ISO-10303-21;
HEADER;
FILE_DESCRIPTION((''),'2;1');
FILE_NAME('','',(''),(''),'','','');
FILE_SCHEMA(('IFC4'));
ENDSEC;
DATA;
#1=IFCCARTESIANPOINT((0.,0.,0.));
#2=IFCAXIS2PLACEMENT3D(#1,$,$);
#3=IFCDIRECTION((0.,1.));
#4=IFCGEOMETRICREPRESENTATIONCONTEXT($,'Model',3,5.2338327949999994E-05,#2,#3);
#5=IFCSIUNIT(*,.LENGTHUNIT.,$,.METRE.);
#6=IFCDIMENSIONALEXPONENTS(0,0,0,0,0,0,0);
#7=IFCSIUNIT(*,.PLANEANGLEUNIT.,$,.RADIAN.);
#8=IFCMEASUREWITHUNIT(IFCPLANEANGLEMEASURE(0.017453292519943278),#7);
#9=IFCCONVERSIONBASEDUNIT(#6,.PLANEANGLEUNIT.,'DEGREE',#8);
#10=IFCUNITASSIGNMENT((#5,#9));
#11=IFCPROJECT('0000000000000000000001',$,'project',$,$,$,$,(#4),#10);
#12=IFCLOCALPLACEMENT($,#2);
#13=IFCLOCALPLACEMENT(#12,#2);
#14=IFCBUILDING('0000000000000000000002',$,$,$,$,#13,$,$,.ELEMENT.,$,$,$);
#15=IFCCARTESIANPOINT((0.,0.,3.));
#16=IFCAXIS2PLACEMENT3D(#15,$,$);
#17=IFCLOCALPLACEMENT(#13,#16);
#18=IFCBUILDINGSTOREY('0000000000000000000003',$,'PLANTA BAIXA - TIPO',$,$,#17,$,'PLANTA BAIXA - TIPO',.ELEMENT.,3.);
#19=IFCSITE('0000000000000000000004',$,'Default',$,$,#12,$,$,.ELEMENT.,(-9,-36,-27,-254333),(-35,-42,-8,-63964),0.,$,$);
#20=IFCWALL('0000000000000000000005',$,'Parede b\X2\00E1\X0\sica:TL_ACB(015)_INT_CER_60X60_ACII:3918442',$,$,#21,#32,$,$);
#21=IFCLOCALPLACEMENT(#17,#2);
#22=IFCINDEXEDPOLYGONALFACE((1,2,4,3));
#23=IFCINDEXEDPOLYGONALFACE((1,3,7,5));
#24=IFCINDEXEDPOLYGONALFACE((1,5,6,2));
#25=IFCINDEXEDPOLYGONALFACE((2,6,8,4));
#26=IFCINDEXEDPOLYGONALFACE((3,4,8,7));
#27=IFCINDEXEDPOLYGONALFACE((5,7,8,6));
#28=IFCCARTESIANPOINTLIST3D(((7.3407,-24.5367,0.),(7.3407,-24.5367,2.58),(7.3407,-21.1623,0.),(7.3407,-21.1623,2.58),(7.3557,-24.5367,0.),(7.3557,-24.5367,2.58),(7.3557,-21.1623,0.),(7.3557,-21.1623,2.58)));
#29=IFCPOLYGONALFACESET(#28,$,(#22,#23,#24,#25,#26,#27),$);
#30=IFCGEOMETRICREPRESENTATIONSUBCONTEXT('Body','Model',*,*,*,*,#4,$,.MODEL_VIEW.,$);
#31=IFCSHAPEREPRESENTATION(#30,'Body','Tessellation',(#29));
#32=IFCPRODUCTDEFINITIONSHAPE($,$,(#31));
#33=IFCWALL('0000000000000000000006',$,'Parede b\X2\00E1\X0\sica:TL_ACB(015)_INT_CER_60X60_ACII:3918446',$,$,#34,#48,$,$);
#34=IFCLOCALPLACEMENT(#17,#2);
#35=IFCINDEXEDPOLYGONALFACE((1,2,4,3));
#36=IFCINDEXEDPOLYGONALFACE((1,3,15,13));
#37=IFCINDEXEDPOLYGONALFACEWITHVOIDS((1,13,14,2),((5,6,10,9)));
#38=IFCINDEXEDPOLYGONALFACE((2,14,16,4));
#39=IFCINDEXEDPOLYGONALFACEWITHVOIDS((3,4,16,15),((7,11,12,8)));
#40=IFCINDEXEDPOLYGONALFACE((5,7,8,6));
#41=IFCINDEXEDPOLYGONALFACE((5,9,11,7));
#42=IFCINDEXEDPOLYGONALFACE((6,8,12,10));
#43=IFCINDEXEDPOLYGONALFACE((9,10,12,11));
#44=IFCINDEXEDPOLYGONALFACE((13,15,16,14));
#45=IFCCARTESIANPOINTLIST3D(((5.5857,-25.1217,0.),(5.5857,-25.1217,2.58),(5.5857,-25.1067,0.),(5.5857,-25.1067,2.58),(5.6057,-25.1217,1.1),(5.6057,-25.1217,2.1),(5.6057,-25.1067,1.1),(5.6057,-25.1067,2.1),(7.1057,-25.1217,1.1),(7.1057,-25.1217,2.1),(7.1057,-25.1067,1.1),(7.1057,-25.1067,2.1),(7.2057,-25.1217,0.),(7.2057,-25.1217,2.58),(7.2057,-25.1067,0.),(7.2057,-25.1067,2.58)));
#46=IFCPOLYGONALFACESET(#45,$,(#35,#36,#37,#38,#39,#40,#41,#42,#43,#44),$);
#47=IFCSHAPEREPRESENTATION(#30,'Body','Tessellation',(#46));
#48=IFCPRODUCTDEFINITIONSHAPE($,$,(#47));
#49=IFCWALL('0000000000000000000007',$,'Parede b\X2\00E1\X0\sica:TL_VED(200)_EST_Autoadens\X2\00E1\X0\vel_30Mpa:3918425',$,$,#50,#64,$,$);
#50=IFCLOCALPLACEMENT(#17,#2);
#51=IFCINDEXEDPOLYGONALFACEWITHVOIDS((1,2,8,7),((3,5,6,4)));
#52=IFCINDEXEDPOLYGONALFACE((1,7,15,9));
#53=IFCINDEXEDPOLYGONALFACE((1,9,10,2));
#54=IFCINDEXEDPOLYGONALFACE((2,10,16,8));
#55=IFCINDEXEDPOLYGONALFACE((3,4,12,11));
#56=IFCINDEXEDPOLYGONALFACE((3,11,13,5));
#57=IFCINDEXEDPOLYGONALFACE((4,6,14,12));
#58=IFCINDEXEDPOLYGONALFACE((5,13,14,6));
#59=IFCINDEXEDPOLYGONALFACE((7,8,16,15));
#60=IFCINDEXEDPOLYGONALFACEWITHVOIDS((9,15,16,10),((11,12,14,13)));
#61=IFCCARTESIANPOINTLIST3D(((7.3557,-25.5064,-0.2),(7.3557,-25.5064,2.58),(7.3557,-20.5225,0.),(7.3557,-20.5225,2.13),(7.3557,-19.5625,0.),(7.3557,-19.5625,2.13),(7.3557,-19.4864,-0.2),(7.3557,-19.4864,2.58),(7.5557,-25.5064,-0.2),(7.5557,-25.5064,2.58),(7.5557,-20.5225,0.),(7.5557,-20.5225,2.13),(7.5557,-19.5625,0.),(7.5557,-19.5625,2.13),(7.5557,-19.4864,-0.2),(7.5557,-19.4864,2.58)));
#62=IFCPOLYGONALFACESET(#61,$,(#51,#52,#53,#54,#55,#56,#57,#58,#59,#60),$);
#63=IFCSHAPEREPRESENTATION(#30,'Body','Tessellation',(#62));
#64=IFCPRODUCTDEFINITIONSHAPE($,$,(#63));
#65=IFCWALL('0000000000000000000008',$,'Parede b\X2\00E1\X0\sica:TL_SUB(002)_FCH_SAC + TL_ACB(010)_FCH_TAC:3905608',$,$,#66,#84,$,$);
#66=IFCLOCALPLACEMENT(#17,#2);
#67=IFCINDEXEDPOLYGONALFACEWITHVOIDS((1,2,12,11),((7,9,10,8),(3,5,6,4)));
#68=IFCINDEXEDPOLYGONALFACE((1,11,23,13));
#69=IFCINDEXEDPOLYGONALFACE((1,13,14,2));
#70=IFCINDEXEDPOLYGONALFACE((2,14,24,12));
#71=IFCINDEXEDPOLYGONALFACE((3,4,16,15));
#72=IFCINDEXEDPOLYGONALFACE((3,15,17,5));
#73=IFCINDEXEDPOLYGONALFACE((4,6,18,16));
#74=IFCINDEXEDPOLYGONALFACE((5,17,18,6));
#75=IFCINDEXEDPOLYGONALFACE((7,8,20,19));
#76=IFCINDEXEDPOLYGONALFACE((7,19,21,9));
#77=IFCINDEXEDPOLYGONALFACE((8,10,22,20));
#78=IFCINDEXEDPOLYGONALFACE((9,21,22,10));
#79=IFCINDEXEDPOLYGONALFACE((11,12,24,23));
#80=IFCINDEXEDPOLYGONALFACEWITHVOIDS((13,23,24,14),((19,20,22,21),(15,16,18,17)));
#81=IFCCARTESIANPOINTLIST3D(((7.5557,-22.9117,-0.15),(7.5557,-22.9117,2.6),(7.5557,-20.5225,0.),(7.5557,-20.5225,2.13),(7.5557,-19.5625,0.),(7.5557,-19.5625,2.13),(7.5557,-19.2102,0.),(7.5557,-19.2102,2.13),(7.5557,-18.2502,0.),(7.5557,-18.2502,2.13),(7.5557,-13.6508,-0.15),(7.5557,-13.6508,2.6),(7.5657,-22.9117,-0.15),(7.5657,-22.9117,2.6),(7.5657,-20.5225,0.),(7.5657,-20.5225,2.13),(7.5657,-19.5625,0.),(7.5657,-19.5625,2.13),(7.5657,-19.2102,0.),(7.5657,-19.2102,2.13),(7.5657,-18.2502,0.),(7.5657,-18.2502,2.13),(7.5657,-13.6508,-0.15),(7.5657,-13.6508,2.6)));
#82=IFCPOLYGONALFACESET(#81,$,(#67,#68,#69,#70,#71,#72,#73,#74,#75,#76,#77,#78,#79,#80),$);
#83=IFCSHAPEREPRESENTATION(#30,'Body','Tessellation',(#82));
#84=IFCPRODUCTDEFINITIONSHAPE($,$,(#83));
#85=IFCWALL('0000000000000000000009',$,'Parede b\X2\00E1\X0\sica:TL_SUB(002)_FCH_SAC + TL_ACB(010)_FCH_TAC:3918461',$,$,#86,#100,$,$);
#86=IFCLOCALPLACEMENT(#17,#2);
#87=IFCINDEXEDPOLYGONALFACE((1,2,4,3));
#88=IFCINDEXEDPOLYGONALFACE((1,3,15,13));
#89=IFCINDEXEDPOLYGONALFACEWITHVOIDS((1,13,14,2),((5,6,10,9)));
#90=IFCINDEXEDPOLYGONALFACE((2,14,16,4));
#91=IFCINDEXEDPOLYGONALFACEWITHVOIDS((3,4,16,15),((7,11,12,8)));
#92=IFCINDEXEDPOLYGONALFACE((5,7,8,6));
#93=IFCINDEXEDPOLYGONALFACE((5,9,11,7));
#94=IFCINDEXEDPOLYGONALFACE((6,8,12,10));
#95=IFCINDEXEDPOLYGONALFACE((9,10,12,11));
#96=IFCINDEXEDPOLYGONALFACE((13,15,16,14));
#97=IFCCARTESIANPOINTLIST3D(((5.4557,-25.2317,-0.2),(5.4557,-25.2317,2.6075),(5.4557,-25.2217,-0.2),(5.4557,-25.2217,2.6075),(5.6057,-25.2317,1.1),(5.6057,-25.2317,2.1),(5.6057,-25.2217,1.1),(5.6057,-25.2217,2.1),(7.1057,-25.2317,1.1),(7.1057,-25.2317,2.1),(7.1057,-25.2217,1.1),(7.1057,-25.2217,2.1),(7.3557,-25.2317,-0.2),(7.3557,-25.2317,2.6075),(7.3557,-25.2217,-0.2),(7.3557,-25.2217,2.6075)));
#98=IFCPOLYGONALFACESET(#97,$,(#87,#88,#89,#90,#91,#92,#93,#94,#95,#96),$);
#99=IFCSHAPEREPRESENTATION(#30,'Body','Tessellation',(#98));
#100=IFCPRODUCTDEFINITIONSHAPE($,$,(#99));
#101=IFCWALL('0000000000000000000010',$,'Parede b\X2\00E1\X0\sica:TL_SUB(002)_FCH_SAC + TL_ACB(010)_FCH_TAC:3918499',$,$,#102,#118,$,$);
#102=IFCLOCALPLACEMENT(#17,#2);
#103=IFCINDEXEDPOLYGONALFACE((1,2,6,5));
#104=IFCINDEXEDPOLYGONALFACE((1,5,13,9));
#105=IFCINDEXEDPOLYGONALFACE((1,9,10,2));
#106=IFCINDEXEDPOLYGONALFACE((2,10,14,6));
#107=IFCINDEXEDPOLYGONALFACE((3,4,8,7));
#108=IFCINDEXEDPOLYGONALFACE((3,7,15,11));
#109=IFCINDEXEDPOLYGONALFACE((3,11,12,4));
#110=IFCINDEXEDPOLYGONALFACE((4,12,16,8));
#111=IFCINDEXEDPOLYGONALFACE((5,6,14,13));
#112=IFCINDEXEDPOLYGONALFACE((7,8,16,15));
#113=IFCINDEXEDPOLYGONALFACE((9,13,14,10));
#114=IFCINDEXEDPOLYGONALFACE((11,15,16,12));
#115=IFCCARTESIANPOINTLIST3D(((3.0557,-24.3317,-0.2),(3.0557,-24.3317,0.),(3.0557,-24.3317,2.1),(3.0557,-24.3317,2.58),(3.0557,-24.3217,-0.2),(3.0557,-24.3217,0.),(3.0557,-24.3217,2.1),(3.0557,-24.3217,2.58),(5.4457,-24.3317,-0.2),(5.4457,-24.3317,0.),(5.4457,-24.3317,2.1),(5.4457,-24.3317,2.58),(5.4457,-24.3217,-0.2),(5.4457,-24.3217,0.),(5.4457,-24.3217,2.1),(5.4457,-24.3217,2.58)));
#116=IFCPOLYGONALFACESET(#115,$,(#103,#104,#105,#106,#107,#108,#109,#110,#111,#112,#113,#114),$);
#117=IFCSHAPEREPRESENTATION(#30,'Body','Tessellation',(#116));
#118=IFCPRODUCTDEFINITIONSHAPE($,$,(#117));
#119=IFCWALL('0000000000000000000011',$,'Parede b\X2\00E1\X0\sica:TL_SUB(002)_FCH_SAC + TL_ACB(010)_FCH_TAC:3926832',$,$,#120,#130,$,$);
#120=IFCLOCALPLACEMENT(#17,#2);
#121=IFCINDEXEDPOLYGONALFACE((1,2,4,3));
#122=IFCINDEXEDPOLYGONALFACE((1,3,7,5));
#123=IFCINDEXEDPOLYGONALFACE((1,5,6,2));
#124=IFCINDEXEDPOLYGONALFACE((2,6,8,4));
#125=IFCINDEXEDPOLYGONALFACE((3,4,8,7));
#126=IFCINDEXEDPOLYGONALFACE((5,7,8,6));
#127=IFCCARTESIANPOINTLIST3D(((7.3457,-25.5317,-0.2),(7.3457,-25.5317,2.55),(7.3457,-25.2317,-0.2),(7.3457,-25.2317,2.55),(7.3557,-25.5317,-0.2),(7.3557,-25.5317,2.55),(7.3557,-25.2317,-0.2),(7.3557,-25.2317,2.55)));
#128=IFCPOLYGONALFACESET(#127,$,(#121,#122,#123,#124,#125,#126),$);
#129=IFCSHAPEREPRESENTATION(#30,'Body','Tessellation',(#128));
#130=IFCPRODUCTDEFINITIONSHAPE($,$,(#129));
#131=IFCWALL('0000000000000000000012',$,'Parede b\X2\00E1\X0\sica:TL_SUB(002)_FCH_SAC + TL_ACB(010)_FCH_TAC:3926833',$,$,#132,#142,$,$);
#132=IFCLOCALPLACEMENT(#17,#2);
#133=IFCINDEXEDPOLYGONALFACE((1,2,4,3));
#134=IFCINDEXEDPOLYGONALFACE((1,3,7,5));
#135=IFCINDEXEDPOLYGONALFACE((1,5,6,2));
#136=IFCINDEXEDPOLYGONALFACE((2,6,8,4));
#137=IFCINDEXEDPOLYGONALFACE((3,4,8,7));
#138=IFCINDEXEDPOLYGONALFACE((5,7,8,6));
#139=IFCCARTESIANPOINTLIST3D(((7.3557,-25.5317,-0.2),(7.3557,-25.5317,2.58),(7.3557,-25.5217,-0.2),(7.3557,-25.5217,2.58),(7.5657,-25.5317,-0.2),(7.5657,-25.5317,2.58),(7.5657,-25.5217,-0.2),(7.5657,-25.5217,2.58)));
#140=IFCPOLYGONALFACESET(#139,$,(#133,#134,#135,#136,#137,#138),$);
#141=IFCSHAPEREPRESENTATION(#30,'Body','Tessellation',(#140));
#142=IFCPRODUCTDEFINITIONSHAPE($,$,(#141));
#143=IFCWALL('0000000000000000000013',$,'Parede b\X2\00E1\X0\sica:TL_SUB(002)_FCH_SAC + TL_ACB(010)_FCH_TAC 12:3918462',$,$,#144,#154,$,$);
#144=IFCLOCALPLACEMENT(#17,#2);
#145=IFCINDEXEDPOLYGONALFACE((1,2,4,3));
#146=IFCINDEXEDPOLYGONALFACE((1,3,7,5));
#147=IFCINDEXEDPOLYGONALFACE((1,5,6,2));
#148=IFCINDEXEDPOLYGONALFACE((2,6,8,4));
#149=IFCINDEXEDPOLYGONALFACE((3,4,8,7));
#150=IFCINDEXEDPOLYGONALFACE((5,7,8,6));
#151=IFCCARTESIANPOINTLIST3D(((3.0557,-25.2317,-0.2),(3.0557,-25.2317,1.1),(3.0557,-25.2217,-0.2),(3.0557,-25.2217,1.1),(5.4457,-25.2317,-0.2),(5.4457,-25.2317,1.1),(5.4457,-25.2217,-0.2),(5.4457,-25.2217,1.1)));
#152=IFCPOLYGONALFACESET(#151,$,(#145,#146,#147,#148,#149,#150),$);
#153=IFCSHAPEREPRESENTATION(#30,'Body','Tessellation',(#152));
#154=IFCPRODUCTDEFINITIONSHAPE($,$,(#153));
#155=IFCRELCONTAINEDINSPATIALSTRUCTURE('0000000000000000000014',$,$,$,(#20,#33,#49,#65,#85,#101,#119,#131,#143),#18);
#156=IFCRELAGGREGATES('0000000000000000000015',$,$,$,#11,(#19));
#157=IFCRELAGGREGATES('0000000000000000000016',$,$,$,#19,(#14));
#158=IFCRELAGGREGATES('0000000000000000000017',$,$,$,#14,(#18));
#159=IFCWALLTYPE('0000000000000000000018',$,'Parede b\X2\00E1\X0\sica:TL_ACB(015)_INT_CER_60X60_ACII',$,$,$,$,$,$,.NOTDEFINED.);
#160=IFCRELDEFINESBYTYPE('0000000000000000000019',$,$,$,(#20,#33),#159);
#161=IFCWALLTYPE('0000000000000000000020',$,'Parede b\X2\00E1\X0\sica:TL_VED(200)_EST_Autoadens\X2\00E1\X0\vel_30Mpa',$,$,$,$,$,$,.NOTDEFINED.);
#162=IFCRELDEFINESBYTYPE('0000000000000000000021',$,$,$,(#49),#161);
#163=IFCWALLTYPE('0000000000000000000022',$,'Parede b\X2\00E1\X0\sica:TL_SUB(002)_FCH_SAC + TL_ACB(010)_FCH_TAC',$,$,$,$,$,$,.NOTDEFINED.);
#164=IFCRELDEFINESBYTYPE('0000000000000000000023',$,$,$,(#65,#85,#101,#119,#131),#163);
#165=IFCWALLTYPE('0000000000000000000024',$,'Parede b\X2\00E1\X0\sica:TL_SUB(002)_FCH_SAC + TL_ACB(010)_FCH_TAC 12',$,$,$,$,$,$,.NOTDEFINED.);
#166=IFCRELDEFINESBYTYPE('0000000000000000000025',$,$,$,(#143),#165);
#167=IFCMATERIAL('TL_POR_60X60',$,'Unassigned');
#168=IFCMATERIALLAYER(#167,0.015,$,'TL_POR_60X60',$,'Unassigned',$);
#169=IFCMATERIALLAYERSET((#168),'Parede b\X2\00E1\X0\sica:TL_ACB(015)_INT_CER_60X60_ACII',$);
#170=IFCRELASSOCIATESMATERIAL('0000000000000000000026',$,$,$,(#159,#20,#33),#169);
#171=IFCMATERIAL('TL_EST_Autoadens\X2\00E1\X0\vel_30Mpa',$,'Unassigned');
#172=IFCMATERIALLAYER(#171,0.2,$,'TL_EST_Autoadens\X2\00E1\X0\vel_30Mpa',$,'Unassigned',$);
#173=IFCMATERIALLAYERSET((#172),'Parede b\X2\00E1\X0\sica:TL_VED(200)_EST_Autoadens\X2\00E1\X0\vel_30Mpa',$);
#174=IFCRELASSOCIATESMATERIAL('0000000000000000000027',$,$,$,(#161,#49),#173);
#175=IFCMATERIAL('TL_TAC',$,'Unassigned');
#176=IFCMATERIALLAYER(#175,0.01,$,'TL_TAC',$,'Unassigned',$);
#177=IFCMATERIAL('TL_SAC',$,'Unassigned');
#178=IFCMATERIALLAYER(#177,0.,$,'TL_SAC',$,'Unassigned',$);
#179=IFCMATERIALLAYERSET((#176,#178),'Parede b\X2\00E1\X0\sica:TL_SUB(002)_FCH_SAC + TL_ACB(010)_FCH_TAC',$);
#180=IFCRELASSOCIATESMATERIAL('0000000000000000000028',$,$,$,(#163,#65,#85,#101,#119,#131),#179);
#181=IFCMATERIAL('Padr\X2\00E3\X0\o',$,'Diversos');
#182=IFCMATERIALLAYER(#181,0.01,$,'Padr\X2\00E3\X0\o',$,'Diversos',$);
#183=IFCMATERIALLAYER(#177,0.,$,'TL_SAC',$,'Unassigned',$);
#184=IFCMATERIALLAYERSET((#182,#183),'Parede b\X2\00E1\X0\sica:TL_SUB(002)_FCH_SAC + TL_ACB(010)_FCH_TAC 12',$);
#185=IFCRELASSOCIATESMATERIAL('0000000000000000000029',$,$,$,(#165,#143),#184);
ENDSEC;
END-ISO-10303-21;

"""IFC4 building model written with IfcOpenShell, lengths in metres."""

from ifc_helpers import new_model, entity, si_unit, converted_unit, direction, frame, frame_2d, origin, place, context, subcontext, project, spatial, rectangle, extrude, material, layer, layer_set, layer_usage, type_object, element, save


model = new_model("IFC4")

# Units and contexts
model_context = context("Model", 3, precision=5.2338327949999994e-05, world=origin(), true_north=direction((0.0, 1.0)))
body_context = subcontext(model_context, "Body", "Model", "MODEL_VIEW")
ifc_project = project(units=[si_unit("LENGTHUNIT", "METRE"), converted_unit("PLANEANGLEUNIT", "DEGREE", entity("IfcPlaneAngleMeasure", 0.017453292519943278), si_unit("PLANEANGLEUNIT", "RADIAN"), dimensions=[0, 0, 0, 0, 0, 0, 0])], contexts=[model_context])

# Site, building, storey
site_placement = place(None, frame((0.0, 0.0, 0.0)))
site = spatial("IfcSite", under=ifc_project, at=site_placement, Name="Default", CompositionType="ELEMENT", RefLatitude=(-9, -36, -27, -254333), RefLongitude=(-35, -42, -8, -63964), RefElevation=0.0)
building_placement = place(site_placement, origin())
building = spatial("IfcBuilding", under=site, at=building_placement, CompositionType="ELEMENT")
storey_placement = place(building_placement, frame((0.0, 0.0, 3.0)))
storey = spatial("IfcBuildingStorey", under=building, at=storey_placement, Name="PLANTA BAIXA - TIPO", LongName="PLANTA BAIXA - TIPO", CompositionType="ELEMENT", Elevation=3.0)

# Shared definitions
ifc_material_1 = material(Name="TL_EST_Autoadensável_30Mpa", Category="Unassigned")

# Shared definitions
ifc_material_2 = material(Name="TL_SAC", Category="Unassigned")

# Wall
ifc_material_3 = material(Name="TL_POR_60X60", Category="Unassigned")
ifc_layer_1 = layer(ifc_material_3, 0.015, Name="TL_POR_60X60", Category="Unassigned")
ifc_layer_set_1 = layer_set([ifc_layer_1], Name="Parede básica:TL_ACB(015)_INT_CER_60X60_ACII")
ifc_layer_usage_1 = layer_usage(ifc_layer_set_1, "AXIS2", "POSITIVE", -0.0075)
wall_type_1 = type_object("IfcWallType", Name="Parede básica:TL_ACB(015)_INT_CER_60X60_ACII", PredefinedType="NOTDEFINED", material=ifc_layer_set_1)
wall_1_placement = place(storey_placement, frame((7.3482, -21.1623, 0.0), z_axis=(0.0, 0.0, 1.0), x_axis=(0.0, -1.0, 0.0)))
element("IfcWall", 1, at=wall_1_placement, inside=storey, type_object=wall_type_1, material=ifc_layer_usage_1, Name="Parede básica:TL_ACB(015)_INT_CER_60X60_ACII:3918442", context=body_context, shape_type="SweptSolid", body=[
    extrude(rectangle(XDim=3.3744, YDim=0.015, at=frame_2d((1.6872, 0.0), x_axis=(-1.0, 0.0))), origin(), (0.0, 0.0, 1.0), 2.58),
])

# Walls, openings
ifc_layer_usage_2 = layer_usage(ifc_layer_set_1, "AXIS2", "POSITIVE", -0.0075)
wall_2_placement = place(storey_placement, frame((7.2057, -25.1142, 0.0), z_axis=(0.0, 0.0, 1.0), x_axis=(-1.0, 0.0, 0.0)))
wall_2 = element("IfcWall", 2, at=wall_2_placement, inside=storey, type_object=wall_type_1, material=ifc_layer_usage_2, Name="Parede básica:TL_ACB(015)_INT_CER_60X60_ACII:3918446", context=body_context, shape_type="SweptSolid", body=[
    extrude(rectangle(XDim=1.62, YDim=0.015, at=frame_2d((0.81, 0.0), x_axis=(-1.0, 0.0))), origin(), (0.0, 0.0, 1.0), 2.58),
])
opening_1_placement = place(wall_2_placement, frame((7.2057, -25.1142, 1.1)))
element("IfcOpeningElement", 3, at=opening_1_placement, cuts=wall_2, PredefinedType="OPENING", context=body_context, shape_type="SweptSolid", body=[
    extrude(rectangle(XDim=1.0, YDim=1.5, at=frame_2d((0.0, 0.0), x_axis=(0.0, 1.0))), frame((-6.3557, 23.5977, 0.5), z_axis=(0.0, 1.0, 0.0), x_axis=(1.0, 0.0, 0.0)), (0.0, 0.0, 1.0), 3.048),
])
ifc_layer_2 = layer(ifc_material_1, 0.2, Name="TL_EST_Autoadensável_30Mpa", Category="Unassigned")
ifc_layer_set_2 = layer_set([ifc_layer_2], Name="Parede básica:TL_VED(200)_EST_Autoadensável_30Mpa")
ifc_layer_usage_3 = layer_usage(ifc_layer_set_2, "AXIS2", "POSITIVE", -0.1)
wall_type_2 = type_object("IfcWallType", Name="Parede básica:TL_VED(200)_EST_Autoadensável_30Mpa", PredefinedType="NOTDEFINED", material=ifc_layer_set_2)
wall_3_placement = place(storey_placement, frame((7.4557, -25.5064, -0.2), z_axis=(0.0, 0.0, 1.0), x_axis=(0.0, 1.0, 0.0)))
wall_3 = element("IfcWall", 4, at=wall_3_placement, inside=storey, type_object=wall_type_2, material=ifc_layer_usage_3, Name="Parede básica:TL_VED(200)_EST_Autoadensável_30Mpa:3918425", context=body_context, shape_type="SweptSolid", body=[
    extrude(rectangle(XDim=6.02, YDim=0.2, at=frame_2d((3.01, 0.0), x_axis=(-1.0, 0.0))), origin(), (0.0, 0.0, 1.0), 2.78),
])
opening_2_placement = place(wall_3_placement, frame((4.9838, -0.1, 0.2)))
element("IfcOpeningElement", 5, at=opening_2_placement, cuts=wall_3, PredefinedType="OPENING", context=body_context, shape_type="SweptSolid", body=[
    extrude(rectangle(XDim=2.13, YDim=0.96, at=frame_2d((1.065, 0.48), x_axis=(1.0, 0.0))), frame((0.0, 0.0, 0.0), z_axis=(0.0, 1.0, 0.0), x_axis=(0.0, 0.0, 1.0)), (0.0, 0.0, 1.0), 0.2),
])

# Wall, openings
ifc_material_4 = material(Name="TL_TAC", Category="Unassigned")
ifc_layer_3 = layer(ifc_material_4, 0.01, Name="TL_TAC", Category="Unassigned")
ifc_layer_4 = layer(ifc_material_2, 0.0, Name="TL_SAC", Category="Unassigned")
ifc_layer_set_3 = layer_set([ifc_layer_3, ifc_layer_4], Name="Parede básica:TL_SUB(002)_FCH_SAC + TL_ACB(010)_FCH_TAC")
ifc_layer_usage_4 = layer_usage(ifc_layer_set_3, "AXIS2", "NEGATIVE", 0.005)
wall_type_3 = type_object("IfcWallType", Name="Parede básica:TL_SUB(002)_FCH_SAC + TL_ACB(010)_FCH_TAC", PredefinedType="NOTDEFINED", material=ifc_layer_set_3)
wall_4_placement = place(storey_placement, frame((7.5607, -22.9117, -0.15), z_axis=(0.0, 0.0, 1.0), x_axis=(0.0, 1.0, 0.0)))
wall_4 = element("IfcWall", 6, at=wall_4_placement, inside=storey, type_object=wall_type_3, material=ifc_layer_usage_4, Name="Parede básica:TL_SUB(002)_FCH_SAC + TL_ACB(010)_FCH_TAC:3905608", context=body_context, shape_type="SweptSolid", body=[
    extrude(rectangle(XDim=9.2609, YDim=0.01, at=frame_2d((4.6305, 0.0), x_axis=(-1.0, 0.0))), origin(), (0.0, 0.0, 1.0), 2.75),
])
opening_3_placement = place(wall_4_placement, frame((22.9117, 7.5607, 0.15)))
element("IfcOpeningElement", 7, at=opening_3_placement, cuts=wall_4, PredefinedType="OPENING", context=body_context, shape_type="SweptSolid", body=[
    extrude(rectangle(XDim=2.13, YDim=0.96, at=frame_2d((0.0, 0.0), x_axis=(1.0, 0.0))), frame((-20.0425, -8.8797, 1.065), z_axis=(0.0, 1.0, 0.0), x_axis=(0.0, 0.0, 1.0)), (0.0, 0.0, 1.0), 3.048),
])
opening_4_placement = place(wall_4_placement, frame((22.9117, 7.5607, 0.15)))
element("IfcOpeningElement", 8, at=opening_4_placement, cuts=wall_4, PredefinedType="OPENING", context=body_context, shape_type="SweptSolid", body=[
    extrude(rectangle(XDim=2.13, YDim=0.96, at=frame_2d((0.0, 0.0), x_axis=(0.0, 1.0))), frame((-18.7302, -8.8797, 1.065), z_axis=(0.0, 1.0, 0.0), x_axis=(-1.0, 0.0, 0.0)), (0.0, 0.0, 1.0), 3.048),
])

# Walls, openings
ifc_layer_usage_5 = layer_usage(ifc_layer_set_3, "AXIS2", "POSITIVE", -0.005)
wall_5_placement = place(storey_placement, frame((7.3557, -25.2267, -0.2), z_axis=(0.0, 0.0, 1.0), x_axis=(-1.0, 0.0, 0.0)))
wall_5 = element("IfcWall", 9, at=wall_5_placement, inside=storey, type_object=wall_type_3, material=ifc_layer_usage_5, Name="Parede básica:TL_SUB(002)_FCH_SAC + TL_ACB(010)_FCH_TAC:3918461", context=body_context, shape_type="SweptSolid", body=[
    extrude(rectangle(XDim=1.9, YDim=0.01, at=frame_2d((0.95, 0.0), x_axis=(-1.0, 0.0))), origin(), (0.0, 0.0, 1.0), 2.8075),
])
opening_5_placement = place(wall_5_placement, frame((7.3557, -25.2267, 1.3)))
element("IfcOpeningElement", 10, at=opening_5_placement, cuts=wall_5, PredefinedType="OPENING", context=body_context, shape_type="SweptSolid", body=[
    extrude(rectangle(XDim=1.0, YDim=1.5, at=frame_2d((0.0, 0.0), x_axis=(0.0, 1.0))), frame((-6.3557, 23.5977, 0.5), z_axis=(0.0, 1.0, 0.0), x_axis=(1.0, 0.0, 0.0)), (0.0, 0.0, 1.0), 3.048),
])
ifc_layer_usage_6 = layer_usage(ifc_layer_set_3, "AXIS2", "NEGATIVE", 0.005)
wall_6_placement = place(storey_placement, frame((5.4457, -24.3267, -0.2), z_axis=(0.0, 0.0, 1.0), x_axis=(-1.0, 0.0, 0.0)))
wall_6 = element("IfcWall", 11, at=wall_6_placement, inside=storey, type_object=wall_type_3, material=ifc_layer_usage_6, Name="Parede básica:TL_SUB(002)_FCH_SAC + TL_ACB(010)_FCH_TAC:3918499", context=body_context, shape_type="SweptSolid", body=[
    extrude(rectangle(XDim=2.39, YDim=0.01, at=frame_2d((1.195, 0.0), x_axis=(-1.0, 0.0))), origin(), (0.0, 0.0, 1.0), 2.78),
])
opening_6_placement = place(wall_6_placement, frame((5.4457, -24.3267, 0.2)))
element("IfcOpeningElement", 12, at=opening_6_placement, cuts=wall_6, PredefinedType="OPENING", context=body_context, shape_type="SweptSolid", body=[
    extrude(rectangle(XDim=2.1, YDim=2.4, at=frame_2d((0.0, 0.0), x_axis=(0.0, 1.0))), frame((-4.2557, 22.7977, 1.05), z_axis=(0.0, 1.0, 0.0), x_axis=(-1.0, 0.0, 0.0)), (0.0, 0.0, 1.0), 3.048),
])

# Walls
ifc_layer_usage_7 = layer_usage(ifc_layer_set_3, "AXIS2", "NEGATIVE", 0.005)
wall_7_placement = place(storey_placement, frame((7.3507, -25.2317, -0.2), z_axis=(0.0, 0.0, 1.0), x_axis=(0.0, -1.0, 0.0)))
element("IfcWall", 13, at=wall_7_placement, inside=storey, type_object=wall_type_3, material=ifc_layer_usage_7, Name="Parede básica:TL_SUB(002)_FCH_SAC + TL_ACB(010)_FCH_TAC:3926832", context=body_context, shape_type="SweptSolid", body=[
    extrude(rectangle(XDim=0.3, YDim=0.01, at=frame_2d((0.15, 0.0), x_axis=(-1.0, 0.0))), origin(), (0.0, 0.0, 1.0), 2.75),
])
ifc_layer_usage_8 = layer_usage(ifc_layer_set_3, "AXIS2", "NEGATIVE", 0.005)
wall_8_placement = place(storey_placement, frame((7.3557, -25.5267, -0.2)))
element("IfcWall", 14, at=wall_8_placement, inside=storey, type_object=wall_type_3, material=ifc_layer_usage_8, Name="Parede básica:TL_SUB(002)_FCH_SAC + TL_ACB(010)_FCH_TAC:3926833", context=body_context, shape_type="SweptSolid", body=[
    extrude(rectangle(XDim=0.21, YDim=0.01, at=frame_2d((0.105, 0.0), x_axis=(-1.0, 0.0))), origin(), (0.0, 0.0, 1.0), 2.78),
])
ifc_material_5 = material(Name="Padrão", Category="Diversos")
ifc_layer_5 = layer(ifc_material_5, 0.01, Name="Padrão", Category="Diversos")
ifc_layer_6 = layer(ifc_material_2, 0.0, Name="TL_SAC", Category="Unassigned")
ifc_layer_set_4 = layer_set([ifc_layer_5, ifc_layer_6], Name="Parede básica:TL_SUB(002)_FCH_SAC + TL_ACB(010)_FCH_TAC 12")
ifc_layer_usage_9 = layer_usage(ifc_layer_set_4, "AXIS2", "POSITIVE", -0.005)
wall_type_4 = type_object("IfcWallType", Name="Parede básica:TL_SUB(002)_FCH_SAC + TL_ACB(010)_FCH_TAC 12", PredefinedType="NOTDEFINED", material=ifc_layer_set_4)
wall_9_placement = place(storey_placement, frame((5.4457, -25.2267, -0.2), z_axis=(0.0, 0.0, 1.0), x_axis=(-1.0, 0.0, 0.0)))
element("IfcWall", 15, at=wall_9_placement, inside=storey, type_object=wall_type_4, material=ifc_layer_usage_9, Name="Parede básica:TL_SUB(002)_FCH_SAC + TL_ACB(010)_FCH_TAC 12:3918462", context=body_context, shape_type="SweptSolid", body=[
    extrude(rectangle(XDim=2.39, YDim=0.01, at=frame_2d((1.195, 0.0), x_axis=(-1.0, 0.0))), origin(), (0.0, 0.0, 1.0), 1.3),
])

save(model, "model.ifc")
